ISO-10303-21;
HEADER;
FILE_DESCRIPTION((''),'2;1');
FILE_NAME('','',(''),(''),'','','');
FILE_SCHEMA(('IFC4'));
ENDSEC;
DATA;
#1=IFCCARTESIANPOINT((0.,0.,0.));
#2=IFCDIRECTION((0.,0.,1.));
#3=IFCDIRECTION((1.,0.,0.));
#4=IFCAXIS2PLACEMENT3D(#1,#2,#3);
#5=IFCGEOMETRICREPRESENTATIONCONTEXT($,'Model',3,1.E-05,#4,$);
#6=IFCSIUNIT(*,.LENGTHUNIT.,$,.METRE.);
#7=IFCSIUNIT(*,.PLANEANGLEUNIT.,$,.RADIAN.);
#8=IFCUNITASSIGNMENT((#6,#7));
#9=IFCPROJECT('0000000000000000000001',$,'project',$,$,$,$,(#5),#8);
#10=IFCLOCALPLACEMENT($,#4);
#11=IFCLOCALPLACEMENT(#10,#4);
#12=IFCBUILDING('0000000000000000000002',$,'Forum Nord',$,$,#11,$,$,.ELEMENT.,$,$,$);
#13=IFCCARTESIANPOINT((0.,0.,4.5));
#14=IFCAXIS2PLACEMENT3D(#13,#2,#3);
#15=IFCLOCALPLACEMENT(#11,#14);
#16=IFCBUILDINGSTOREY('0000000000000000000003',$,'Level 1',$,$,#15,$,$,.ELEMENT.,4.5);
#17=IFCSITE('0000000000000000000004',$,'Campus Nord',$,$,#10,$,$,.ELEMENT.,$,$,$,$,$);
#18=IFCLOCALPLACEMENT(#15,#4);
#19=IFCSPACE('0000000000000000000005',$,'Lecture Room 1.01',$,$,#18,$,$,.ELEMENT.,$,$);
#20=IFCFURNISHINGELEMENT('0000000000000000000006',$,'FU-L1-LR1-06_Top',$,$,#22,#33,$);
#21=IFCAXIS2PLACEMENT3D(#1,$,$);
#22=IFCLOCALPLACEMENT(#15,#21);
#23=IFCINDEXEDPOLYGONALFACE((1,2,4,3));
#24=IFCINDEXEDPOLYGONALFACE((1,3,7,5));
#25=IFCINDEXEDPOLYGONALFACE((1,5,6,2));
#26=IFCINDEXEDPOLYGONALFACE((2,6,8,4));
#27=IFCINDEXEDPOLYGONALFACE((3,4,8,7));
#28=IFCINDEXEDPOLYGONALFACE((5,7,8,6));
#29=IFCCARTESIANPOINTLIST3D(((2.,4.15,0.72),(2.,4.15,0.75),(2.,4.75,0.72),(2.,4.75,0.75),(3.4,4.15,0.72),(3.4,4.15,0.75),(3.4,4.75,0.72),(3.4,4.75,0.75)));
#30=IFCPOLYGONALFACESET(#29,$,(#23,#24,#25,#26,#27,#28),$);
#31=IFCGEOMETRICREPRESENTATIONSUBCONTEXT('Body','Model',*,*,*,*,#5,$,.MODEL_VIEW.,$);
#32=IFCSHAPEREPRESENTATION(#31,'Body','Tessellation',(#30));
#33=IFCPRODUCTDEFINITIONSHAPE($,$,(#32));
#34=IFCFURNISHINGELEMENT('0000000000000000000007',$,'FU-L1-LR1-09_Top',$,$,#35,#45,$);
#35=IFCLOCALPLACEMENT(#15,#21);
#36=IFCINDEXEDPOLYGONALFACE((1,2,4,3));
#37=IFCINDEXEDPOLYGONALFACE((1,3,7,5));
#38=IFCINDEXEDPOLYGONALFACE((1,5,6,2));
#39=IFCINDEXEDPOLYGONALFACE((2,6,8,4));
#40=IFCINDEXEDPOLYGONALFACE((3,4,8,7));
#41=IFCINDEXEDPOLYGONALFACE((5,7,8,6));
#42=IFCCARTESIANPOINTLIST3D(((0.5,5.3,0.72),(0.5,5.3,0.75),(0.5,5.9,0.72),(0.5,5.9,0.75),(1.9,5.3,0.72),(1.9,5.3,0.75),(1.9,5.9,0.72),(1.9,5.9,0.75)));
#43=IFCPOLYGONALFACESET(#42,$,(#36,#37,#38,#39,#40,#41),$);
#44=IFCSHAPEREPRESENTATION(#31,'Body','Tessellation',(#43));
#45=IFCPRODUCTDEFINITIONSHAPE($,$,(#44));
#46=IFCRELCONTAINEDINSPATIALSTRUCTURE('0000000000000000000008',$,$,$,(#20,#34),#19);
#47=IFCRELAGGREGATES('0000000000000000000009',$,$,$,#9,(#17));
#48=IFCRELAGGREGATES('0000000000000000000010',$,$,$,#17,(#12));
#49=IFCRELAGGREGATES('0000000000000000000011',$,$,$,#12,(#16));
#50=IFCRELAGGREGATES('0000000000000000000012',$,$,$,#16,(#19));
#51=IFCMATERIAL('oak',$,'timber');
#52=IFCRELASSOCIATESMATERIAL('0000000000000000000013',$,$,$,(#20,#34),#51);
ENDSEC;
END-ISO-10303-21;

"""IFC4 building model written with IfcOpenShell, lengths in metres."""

from ifc_helpers import new_model, si_unit, frame, frame_2d, origin_with_axes, place, context, subcontext, project, spatial, rectangle, extrude, material, element, save


model = new_model("IFC4")

# Units and contexts
model_context = context("Model", 3, precision=1e-05, world=origin_with_axes())
body_context = subcontext(model_context, "Body", "Model", "MODEL_VIEW")
ifc_project = project(units=[si_unit("LENGTHUNIT", "METRE"), si_unit("PLANEANGLEUNIT", "RADIAN")], contexts=[model_context])

# Site, building, storey
site_placement = place(None, origin_with_axes())
site = spatial("IfcSite", under=ifc_project, at=site_placement, Name="Campus Nord", CompositionType="ELEMENT")
building_placement = place(site_placement, origin_with_axes())
building = spatial("IfcBuilding", under=site, at=building_placement, Name="Forum Nord", CompositionType="ELEMENT")
storey_placement = place(building_placement, frame((0.0, 0.0, 4.5), z_axis=(0.0, 0.0, 1.0), x_axis=(1.0, 0.0, 0.0)))
storey = spatial("IfcBuildingStorey", under=building, at=storey_placement, Name="Level 1", CompositionType="ELEMENT", Elevation=4.5)

# Shared definitions
space_placement = place(storey_placement, origin_with_axes())
space = spatial("IfcSpace", under=storey, at=space_placement, Name="Lecture Room 1.01", CompositionType="ELEMENT")

# Furnishing elements
ifc_material_1 = material(Name="oak", Category="timber")
for number, where, z_axis, x_axis, name in (
    (1, (2.0, 4.15, 0.0), (0.0, 0.0, 1.0), (1.0, 0.0, 0.0), "FU-L1-LR1-06_Top"),
    (2, (0.5, 5.3, 0.0), (0.0, 0.0, 1.0), (1.0, 0.0, 0.0), "FU-L1-LR1-09_Top"),
):
    element("IfcFurnishingElement", number, at=place(storey_placement, frame(where, z_axis=z_axis, x_axis=x_axis)), inside=space, material=ifc_material_1, Name=name, context=body_context, shape_type="SweptSolid", body=[
        extrude(rectangle(XDim=1.4, YDim=0.6, at=frame_2d((0.7, 0.3), x_axis=(1.0, 0.0))), frame((0.0, 0.0, 0.72), z_axis=(0.0, 0.0, 1.0), x_axis=(1.0, 0.0, 0.0)), (0.0, 0.0, 1.0), 0.03),
    ])

save(model, "model.ifc")
